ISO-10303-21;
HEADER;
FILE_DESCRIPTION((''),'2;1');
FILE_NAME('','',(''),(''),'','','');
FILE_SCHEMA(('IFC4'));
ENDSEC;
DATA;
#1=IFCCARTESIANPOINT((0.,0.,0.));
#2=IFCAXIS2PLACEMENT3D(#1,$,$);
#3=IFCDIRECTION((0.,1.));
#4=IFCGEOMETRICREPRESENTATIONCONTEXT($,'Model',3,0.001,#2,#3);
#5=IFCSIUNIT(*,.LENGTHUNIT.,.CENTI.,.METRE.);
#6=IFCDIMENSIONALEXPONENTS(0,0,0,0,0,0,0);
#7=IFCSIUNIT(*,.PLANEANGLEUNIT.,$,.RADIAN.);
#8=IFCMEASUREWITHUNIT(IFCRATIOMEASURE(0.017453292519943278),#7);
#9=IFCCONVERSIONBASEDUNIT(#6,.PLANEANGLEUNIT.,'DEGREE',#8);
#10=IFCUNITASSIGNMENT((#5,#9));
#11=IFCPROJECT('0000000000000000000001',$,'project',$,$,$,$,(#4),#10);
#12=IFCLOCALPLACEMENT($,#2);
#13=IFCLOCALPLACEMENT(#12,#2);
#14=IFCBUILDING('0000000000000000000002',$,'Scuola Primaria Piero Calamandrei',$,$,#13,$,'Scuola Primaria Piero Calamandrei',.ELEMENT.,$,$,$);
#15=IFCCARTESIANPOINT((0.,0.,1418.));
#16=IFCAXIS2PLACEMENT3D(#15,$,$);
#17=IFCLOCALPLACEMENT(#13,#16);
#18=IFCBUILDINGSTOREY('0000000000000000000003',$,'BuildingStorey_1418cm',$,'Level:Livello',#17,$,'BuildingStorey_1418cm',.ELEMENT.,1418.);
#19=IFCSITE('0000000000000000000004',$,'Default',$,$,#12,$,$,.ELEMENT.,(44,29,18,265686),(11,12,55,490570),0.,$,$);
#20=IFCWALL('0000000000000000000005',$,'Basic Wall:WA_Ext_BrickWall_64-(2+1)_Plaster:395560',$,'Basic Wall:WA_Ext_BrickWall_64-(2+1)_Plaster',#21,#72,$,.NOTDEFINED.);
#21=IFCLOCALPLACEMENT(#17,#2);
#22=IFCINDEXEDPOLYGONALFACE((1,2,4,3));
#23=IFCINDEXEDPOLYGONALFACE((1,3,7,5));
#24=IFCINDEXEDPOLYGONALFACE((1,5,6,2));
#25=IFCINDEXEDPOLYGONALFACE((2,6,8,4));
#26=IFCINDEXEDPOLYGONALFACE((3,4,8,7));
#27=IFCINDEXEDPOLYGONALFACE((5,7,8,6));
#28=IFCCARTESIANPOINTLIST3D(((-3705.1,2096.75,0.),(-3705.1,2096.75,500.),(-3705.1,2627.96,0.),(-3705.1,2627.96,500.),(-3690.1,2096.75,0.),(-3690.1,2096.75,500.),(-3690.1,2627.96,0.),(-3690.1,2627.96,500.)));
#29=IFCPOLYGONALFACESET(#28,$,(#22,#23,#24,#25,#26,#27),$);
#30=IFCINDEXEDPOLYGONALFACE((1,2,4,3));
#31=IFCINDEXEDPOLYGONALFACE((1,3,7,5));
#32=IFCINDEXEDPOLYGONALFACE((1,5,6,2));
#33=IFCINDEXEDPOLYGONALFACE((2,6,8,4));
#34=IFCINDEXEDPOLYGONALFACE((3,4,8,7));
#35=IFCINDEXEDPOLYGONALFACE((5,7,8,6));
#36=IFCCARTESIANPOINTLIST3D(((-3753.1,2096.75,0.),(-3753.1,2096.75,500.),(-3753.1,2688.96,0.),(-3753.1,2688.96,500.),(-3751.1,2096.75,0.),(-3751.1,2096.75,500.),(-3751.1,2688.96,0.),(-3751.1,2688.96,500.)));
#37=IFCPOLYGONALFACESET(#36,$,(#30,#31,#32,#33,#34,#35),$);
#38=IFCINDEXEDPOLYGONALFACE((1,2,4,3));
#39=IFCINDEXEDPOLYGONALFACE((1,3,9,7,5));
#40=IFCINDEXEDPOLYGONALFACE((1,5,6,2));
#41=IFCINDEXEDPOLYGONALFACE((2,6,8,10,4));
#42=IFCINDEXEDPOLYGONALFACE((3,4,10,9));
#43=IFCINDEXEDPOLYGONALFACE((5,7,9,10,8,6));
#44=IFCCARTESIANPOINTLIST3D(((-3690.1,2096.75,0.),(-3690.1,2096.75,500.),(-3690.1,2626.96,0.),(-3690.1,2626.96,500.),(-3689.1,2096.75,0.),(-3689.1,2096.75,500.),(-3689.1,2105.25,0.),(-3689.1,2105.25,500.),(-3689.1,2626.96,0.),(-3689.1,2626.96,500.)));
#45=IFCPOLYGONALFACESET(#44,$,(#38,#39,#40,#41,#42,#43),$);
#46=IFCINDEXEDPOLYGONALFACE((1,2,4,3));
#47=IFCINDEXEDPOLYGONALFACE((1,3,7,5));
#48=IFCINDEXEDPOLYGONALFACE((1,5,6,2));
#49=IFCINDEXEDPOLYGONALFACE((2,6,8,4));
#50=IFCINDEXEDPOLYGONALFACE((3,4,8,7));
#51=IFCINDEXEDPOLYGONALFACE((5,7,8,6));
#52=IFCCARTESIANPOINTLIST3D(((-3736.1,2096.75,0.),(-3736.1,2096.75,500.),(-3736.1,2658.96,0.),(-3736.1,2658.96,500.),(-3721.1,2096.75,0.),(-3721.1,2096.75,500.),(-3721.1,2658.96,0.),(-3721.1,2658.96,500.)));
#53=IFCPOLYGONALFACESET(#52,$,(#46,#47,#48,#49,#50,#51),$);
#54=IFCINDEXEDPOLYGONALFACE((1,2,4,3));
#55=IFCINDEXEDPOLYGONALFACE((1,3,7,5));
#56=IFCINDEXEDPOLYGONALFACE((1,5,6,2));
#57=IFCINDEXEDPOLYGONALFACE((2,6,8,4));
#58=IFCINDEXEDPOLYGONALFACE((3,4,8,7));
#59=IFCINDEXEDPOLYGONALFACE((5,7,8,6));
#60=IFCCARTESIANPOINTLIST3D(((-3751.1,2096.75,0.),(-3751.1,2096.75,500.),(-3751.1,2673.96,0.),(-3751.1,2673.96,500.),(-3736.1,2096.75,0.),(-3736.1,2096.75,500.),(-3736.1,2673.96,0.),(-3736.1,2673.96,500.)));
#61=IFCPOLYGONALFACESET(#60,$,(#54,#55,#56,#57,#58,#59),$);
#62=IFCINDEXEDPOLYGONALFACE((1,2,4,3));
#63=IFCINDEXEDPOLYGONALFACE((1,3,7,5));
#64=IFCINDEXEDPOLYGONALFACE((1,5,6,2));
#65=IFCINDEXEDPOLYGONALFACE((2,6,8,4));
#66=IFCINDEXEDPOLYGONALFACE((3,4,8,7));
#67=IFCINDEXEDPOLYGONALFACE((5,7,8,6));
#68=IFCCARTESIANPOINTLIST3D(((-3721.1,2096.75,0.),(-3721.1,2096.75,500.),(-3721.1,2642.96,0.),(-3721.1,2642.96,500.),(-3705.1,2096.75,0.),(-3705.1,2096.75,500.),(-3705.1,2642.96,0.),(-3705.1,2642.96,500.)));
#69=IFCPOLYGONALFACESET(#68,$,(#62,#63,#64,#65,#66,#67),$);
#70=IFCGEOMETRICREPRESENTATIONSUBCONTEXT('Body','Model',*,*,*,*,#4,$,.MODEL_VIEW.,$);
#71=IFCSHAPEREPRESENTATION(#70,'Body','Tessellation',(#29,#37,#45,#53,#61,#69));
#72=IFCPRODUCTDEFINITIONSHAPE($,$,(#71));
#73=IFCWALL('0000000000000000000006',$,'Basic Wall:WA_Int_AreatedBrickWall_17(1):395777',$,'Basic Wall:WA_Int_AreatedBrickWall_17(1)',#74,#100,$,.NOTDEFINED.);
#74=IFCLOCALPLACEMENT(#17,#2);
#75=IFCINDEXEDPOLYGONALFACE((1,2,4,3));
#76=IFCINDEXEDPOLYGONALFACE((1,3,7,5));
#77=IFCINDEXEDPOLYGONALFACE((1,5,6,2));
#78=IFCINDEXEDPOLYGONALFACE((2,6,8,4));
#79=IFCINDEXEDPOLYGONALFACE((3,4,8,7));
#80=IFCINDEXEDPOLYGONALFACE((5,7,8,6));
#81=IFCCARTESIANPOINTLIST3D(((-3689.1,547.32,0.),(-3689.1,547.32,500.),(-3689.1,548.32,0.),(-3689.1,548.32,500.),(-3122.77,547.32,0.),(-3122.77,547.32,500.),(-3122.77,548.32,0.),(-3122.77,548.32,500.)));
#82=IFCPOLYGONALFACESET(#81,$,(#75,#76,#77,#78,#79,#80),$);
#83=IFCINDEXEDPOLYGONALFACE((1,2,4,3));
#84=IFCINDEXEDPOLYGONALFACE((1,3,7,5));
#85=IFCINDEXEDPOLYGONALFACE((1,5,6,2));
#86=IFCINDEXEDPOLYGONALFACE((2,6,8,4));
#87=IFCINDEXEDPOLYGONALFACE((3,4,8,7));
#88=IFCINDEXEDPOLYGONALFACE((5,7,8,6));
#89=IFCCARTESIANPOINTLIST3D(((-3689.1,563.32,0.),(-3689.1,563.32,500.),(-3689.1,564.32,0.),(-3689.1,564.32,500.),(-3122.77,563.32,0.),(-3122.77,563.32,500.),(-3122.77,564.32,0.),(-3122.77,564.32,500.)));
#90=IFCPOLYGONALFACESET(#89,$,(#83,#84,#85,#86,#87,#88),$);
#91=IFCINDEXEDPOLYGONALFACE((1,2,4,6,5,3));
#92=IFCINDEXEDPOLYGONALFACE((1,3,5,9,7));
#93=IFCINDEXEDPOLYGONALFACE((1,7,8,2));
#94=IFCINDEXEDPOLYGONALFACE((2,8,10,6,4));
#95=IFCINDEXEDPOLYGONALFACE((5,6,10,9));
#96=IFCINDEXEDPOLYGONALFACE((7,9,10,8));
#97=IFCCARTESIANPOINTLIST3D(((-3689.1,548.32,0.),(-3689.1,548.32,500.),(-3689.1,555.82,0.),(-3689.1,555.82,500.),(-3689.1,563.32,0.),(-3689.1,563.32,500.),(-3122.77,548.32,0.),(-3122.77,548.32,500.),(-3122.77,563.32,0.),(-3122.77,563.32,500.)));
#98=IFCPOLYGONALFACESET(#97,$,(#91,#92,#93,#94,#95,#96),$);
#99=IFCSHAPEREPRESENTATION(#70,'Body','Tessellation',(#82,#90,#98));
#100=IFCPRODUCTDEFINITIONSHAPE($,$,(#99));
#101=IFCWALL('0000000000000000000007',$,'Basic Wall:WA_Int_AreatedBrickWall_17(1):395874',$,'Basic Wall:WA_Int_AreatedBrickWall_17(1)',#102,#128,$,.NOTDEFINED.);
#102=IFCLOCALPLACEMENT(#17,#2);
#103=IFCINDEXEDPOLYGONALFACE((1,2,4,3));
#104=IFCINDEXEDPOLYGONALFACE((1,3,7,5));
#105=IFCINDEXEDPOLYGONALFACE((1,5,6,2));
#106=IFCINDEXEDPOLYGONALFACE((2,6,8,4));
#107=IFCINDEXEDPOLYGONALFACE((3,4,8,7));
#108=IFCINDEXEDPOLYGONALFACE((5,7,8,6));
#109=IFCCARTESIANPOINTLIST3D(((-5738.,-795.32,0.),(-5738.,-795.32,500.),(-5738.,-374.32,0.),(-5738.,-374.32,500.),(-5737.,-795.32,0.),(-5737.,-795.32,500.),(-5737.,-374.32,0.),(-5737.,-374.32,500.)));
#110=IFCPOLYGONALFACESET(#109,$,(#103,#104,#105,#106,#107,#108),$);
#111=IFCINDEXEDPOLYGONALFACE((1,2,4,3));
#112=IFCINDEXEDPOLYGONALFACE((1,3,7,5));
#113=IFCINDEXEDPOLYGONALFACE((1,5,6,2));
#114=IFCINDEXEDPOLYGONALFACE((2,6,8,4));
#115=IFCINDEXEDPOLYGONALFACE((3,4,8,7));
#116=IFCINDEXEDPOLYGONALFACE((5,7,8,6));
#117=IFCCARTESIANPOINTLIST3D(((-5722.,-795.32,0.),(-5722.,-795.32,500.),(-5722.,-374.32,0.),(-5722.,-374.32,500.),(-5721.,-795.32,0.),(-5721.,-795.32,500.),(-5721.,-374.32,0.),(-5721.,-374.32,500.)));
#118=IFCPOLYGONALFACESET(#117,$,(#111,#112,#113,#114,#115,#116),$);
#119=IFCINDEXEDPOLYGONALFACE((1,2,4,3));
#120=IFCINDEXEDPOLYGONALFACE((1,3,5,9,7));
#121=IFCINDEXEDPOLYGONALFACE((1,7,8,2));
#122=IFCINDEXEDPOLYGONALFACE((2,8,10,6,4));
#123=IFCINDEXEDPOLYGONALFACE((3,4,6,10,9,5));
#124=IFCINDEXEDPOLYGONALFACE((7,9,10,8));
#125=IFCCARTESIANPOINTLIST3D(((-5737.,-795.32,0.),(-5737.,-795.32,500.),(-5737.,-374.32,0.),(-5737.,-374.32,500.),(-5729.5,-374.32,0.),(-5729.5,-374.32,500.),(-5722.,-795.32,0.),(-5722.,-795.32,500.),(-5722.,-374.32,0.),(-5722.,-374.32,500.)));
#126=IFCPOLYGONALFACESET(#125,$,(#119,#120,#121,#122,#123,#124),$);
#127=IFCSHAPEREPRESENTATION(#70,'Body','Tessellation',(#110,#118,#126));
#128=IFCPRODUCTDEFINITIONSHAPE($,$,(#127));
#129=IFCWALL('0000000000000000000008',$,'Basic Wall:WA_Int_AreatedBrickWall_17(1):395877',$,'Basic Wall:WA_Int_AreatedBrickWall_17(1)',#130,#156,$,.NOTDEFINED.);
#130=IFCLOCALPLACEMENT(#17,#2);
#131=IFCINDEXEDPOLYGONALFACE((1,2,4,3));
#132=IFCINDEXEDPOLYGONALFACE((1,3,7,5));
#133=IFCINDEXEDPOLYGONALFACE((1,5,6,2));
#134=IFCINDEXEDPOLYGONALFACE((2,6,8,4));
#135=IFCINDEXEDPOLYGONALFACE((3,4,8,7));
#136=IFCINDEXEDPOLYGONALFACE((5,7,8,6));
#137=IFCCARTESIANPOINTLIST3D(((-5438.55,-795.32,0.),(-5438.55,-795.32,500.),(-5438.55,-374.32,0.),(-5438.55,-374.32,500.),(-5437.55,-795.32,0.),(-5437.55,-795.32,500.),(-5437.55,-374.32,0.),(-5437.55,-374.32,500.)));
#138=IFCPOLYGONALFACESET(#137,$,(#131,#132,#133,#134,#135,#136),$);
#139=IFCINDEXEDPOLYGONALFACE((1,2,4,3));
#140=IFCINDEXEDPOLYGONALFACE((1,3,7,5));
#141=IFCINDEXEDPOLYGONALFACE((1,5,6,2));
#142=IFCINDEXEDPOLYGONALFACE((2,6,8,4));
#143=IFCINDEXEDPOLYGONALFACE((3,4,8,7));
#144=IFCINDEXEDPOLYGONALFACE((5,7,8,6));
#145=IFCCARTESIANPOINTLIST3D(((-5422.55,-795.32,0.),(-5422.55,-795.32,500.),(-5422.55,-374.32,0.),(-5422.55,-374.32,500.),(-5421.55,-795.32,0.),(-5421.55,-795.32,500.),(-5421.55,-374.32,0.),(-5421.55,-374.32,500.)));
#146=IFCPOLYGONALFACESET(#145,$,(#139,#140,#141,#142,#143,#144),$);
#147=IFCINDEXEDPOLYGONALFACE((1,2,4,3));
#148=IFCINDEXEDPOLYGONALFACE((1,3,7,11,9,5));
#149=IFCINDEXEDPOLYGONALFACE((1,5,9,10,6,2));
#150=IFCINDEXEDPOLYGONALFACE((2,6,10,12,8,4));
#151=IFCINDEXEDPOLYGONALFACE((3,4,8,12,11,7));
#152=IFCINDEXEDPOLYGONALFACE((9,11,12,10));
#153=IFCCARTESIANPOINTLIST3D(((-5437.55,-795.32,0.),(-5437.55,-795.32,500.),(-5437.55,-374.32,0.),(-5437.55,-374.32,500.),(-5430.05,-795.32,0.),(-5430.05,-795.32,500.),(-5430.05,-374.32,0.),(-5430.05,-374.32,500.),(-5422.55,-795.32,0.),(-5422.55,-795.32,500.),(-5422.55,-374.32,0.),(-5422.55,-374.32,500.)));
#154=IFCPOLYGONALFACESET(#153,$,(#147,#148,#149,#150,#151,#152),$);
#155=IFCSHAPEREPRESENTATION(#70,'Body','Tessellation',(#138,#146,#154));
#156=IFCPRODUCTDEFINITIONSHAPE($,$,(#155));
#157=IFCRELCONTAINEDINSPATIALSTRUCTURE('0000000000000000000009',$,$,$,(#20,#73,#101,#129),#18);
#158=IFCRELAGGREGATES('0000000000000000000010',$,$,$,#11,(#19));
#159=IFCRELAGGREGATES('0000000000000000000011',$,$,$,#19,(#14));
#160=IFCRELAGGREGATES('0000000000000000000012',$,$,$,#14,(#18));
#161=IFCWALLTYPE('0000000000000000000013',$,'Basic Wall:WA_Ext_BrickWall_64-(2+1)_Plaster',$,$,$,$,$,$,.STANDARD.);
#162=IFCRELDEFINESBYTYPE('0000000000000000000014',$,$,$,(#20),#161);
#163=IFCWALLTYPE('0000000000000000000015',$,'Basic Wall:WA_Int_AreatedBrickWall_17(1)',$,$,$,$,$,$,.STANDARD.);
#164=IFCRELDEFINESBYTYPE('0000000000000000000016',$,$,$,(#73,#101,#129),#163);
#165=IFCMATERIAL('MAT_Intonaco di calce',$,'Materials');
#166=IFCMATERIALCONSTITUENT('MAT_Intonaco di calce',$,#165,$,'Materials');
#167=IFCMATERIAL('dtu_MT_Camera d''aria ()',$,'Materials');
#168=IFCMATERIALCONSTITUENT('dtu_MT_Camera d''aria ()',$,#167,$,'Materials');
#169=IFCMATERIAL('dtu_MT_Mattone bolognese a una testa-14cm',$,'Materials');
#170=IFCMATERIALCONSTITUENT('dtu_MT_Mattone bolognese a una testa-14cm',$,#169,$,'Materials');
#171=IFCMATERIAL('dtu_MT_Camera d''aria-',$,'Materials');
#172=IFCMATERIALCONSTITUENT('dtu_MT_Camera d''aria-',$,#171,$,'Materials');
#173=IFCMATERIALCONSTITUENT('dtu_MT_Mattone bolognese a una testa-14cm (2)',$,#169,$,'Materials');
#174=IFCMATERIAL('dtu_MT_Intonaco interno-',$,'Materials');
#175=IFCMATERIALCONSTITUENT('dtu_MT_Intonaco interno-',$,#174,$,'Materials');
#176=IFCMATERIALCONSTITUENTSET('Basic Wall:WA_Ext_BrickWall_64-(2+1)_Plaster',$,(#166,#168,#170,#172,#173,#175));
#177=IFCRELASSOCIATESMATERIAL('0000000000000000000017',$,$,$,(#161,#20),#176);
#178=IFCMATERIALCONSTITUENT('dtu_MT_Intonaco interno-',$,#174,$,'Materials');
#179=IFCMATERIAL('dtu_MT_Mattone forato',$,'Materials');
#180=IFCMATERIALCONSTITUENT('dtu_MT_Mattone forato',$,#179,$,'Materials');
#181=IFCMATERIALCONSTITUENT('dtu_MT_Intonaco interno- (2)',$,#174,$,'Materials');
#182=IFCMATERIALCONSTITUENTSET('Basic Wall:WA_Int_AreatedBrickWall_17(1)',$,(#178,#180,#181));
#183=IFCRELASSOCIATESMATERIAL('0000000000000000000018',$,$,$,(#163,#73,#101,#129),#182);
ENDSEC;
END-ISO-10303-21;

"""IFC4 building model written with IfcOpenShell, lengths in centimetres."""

from ifc_helpers import new_model, entity, si_unit, converted_unit, direction, frame, origin, place, context, subcontext, project, spatial, indexed_curve, outline, extrude, material, constituent, constituent_set, type_object, element, save


model = new_model("IFC4")

# Units and contexts
model_context = context("Model", 3, precision=0.001, world=origin(), true_north=direction((0.0, 1.0)))
body_context = subcontext(model_context, "Body", "Model", "MODEL_VIEW")
ifc_project = project(units=[si_unit("LENGTHUNIT", "METRE", prefix="CENTI"), converted_unit("PLANEANGLEUNIT", "DEGREE", entity("IfcRatioMeasure", 0.017453292519943278), si_unit("PLANEANGLEUNIT", "RADIAN"), dimensions=[0, 0, 0, 0, 0, 0, 0])], contexts=[model_context])

# Site, building, storey
site_placement = place(None, origin())
site = spatial("IfcSite", under=ifc_project, at=site_placement, Name="Default", CompositionType="ELEMENT", RefLatitude=(44, 29, 18, 265686), RefLongitude=(11, 12, 55, 490570), RefElevation=0.0)
building_placement = place(site_placement, origin())
building = spatial("IfcBuilding", under=site, at=building_placement, Name="Scuola Primaria Piero Calamandrei", LongName="Scuola Primaria Piero Calamandrei", CompositionType="ELEMENT")
storey_placement = place(building_placement, frame((0.0, 0.0, 1418.0)))
storey = spatial("IfcBuildingStorey", under=building, at=storey_placement, Name="BuildingStorey_1418cm", ObjectType="Level:Livello", LongName="BuildingStorey_1418cm", CompositionType="ELEMENT", Elevation=1418.0)

# Shared definitions
ifc_material_1 = material(Name="MAT_Intonaco di calce", Category="Materials")
ifc_constituent_1 = constituent(ifc_material_1, Name="MAT_Intonaco di calce", Category="Materials")
ifc_material_2 = material(Name="dtu_MT_Camera d'aria ()", Category="Materials")
ifc_constituent_2 = constituent(ifc_material_2, Name="dtu_MT_Camera d'aria ()", Category="Materials")
ifc_material_3 = material(Name="dtu_MT_Mattone bolognese a una testa-14cm", Category="Materials")
ifc_constituent_3 = constituent(ifc_material_3, Name="dtu_MT_Mattone bolognese a una testa-14cm", Category="Materials")
ifc_material_4 = material(Name="dtu_MT_Camera d'aria-", Category="Materials")
ifc_constituent_4 = constituent(ifc_material_4, Name="dtu_MT_Camera d'aria-", Category="Materials")
ifc_constituent_5 = constituent(ifc_material_3, Name="dtu_MT_Mattone bolognese a una testa-14cm (2)", Category="Materials")
ifc_material_5 = material(Name="dtu_MT_Intonaco interno-", Category="Materials")
ifc_constituent_6 = constituent(ifc_material_5, Name="dtu_MT_Intonaco interno-", Category="Materials")
ifc_constituent_set_1 = constituent_set(constituents=[ifc_constituent_1, ifc_constituent_2, ifc_constituent_3, ifc_constituent_4, ifc_constituent_5, ifc_constituent_6], Name="Basic Wall:WA_Ext_BrickWall_64-(2+1)_Plaster")
wall_type_1 = type_object("IfcWallType", Name="Basic Wall:WA_Ext_BrickWall_64-(2+1)_Plaster", PredefinedType="STANDARD", material=ifc_constituent_set_1)

# Wall
wall_1_placement = place(storey_placement, frame((-3721.1, 2096.75, 0.0), z_axis=(0.0, 0.0, 1.0), x_axis=(0.0, 1.0, 0.0)))
element("IfcWall", 1, at=wall_1_placement, inside=storey, type_object=wall_type_1, material=ifc_constituent_set_1, Name="Basic Wall:WA_Ext_BrickWall_64-(2+1)_Plaster:395560", ObjectType="Basic Wall:WA_Ext_BrickWall_64-(2+1)_Plaster", PredefinedType="NOTDEFINED", context=body_context, shape_type="SweptSolid", body=[
    extrude(outline(indexed_curve([(-265.61, -7.5), (265.61, -7.5), (265.61, 7.5), (-265.61, 7.5), (-265.61, -7.5)], self_intersect=False)), frame((265.61, -23.5, 0.0)), (0.0, 0.0, 1.0), 500.0),
    extrude(outline(indexed_curve([(-1.0, -296.11), (1.0, -296.11), (1.0, 296.11), (-1.0, 296.11), (-1.0, -296.11)], self_intersect=False)), frame((296.11, 31.0, 0.0), z_axis=(0.0, 0.0, 1.0), x_axis=(0.0, -1.0, 0.0)), (0.0, 0.0, 1.0), 500.0),
    extrude(outline(indexed_curve([(-205.29, -0.4), (316.43, -0.4), (316.43, 0.6), (-213.79, 0.6), (-213.79, -0.4), (-205.29, -0.4)], self_intersect=False)), frame((213.79, -31.6, 0.0)), (0.0, 0.0, 1.0), 500.0),
    extrude(outline(indexed_curve([(-281.11, -7.5), (281.11, -7.5), (281.11, 7.5), (-281.11, 7.5), (-281.11, -7.5)], self_intersect=False)), frame((281.11, 7.5, 0.0)), (0.0, 0.0, 1.0), 500.0),
    extrude(outline(indexed_curve([(-288.61, -7.5), (288.61, -7.5), (288.61, 7.5), (-288.61, 7.5), (-288.61, -7.5)], self_intersect=False)), frame((288.61, 22.5, 0.0)), (0.0, 0.0, 1.0), 500.0),
    extrude(outline(indexed_curve([(-273.11, -8.0), (273.11, -8.0), (273.11, 8.0), (-273.11, 8.0), (-273.11, -8.0)], self_intersect=False)), frame((273.11, -8.0, 0.0)), (0.0, 0.0, 1.0), 500.0),
])

# Walls
ifc_constituent_7 = constituent(ifc_material_5, Name="dtu_MT_Intonaco interno-", Category="Materials")
ifc_material_6 = material(Name="dtu_MT_Mattone forato", Category="Materials")
ifc_constituent_8 = constituent(ifc_material_6, Name="dtu_MT_Mattone forato", Category="Materials")
ifc_constituent_9 = constituent(ifc_material_5, Name="dtu_MT_Intonaco interno- (2)", Category="Materials")
ifc_constituent_set_2 = constituent_set(constituents=[ifc_constituent_7, ifc_constituent_8, ifc_constituent_9], Name="Basic Wall:WA_Int_AreatedBrickWall_17(1)")
wall_type_2 = type_object("IfcWallType", Name="Basic Wall:WA_Int_AreatedBrickWall_17(1)", PredefinedType="STANDARD", material=ifc_constituent_set_2)
wall_2_placement = place(storey_placement, frame((-3689.1, 555.82, 0.0)))
element("IfcWall", 2, at=wall_2_placement, inside=storey, type_object=wall_type_2, material=ifc_constituent_set_2, Name="Basic Wall:WA_Int_AreatedBrickWall_17(1):395777", ObjectType="Basic Wall:WA_Int_AreatedBrickWall_17(1)", PredefinedType="NOTDEFINED", context=body_context, shape_type="SweptSolid", body=[
    extrude(outline(indexed_curve([(-0.5, -283.17), (0.5, -283.17), (0.5, 283.17), (-0.5, 283.17), (-0.5, -283.17)], self_intersect=False)), frame((283.17, -8.0, 0.0), z_axis=(0.0, 0.0, 1.0), x_axis=(0.0, 1.0, 0.0)), (0.0, 0.0, 1.0), 500.0),
    extrude(outline(indexed_curve([(-0.5, -283.17), (0.5, -283.17), (0.5, 283.17), (-0.5, 283.17), (-0.5, -283.17)], self_intersect=False)), frame((283.17, 8.0, 0.0), z_axis=(0.0, 0.0, 1.0), x_axis=(0.0, -1.0, 0.0)), (0.0, 0.0, 1.0), 500.0),
    extrude(outline(indexed_curve([(-226.53, -7.5), (339.8, -7.5), (339.8, 7.5), (-226.53, 7.5), (-226.53, 0.0), (-226.53, -7.5)], self_intersect=False)), frame((226.53, 0.0, 0.0)), (0.0, 0.0, 1.0), 500.0),
])
wall_3_placement = place(storey_placement, frame((-5729.5, -374.32, 0.0), z_axis=(0.0, 0.0, 1.0), x_axis=(0.0, -1.0, 0.0)))
element("IfcWall", 3, at=wall_3_placement, inside=storey, type_object=wall_type_2, material=ifc_constituent_set_2, Name="Basic Wall:WA_Int_AreatedBrickWall_17(1):395874", ObjectType="Basic Wall:WA_Int_AreatedBrickWall_17(1)", PredefinedType="NOTDEFINED", context=body_context, shape_type="SweptSolid", body=[
    extrude(outline(indexed_curve([(-0.5, -210.5), (0.5, -210.5), (0.5, 210.5), (-0.5, 210.5), (-0.5, -210.5)], self_intersect=False)), frame((210.5, -8.0, 0.0), z_axis=(0.0, 0.0, 1.0), x_axis=(0.0, 1.0, 0.0)), (0.0, 0.0, 1.0), 500.0),
    extrude(outline(indexed_curve([(-0.5, -210.5), (0.5, -210.5), (0.5, 210.5), (-0.5, 210.5), (-0.5, -210.5)], self_intersect=False)), frame((210.5, 8.0, 0.0), z_axis=(0.0, 0.0, 1.0), x_axis=(0.0, -1.0, 0.0)), (0.0, 0.0, 1.0), 500.0),
    extrude(outline(indexed_curve([(-168.4, -7.5), (252.6, -7.5), (252.6, 7.5), (-168.4, 7.5), (-168.4, 0.0), (-168.4, -7.5)], self_intersect=False)), frame((168.4, 0.0, 0.0)), (0.0, 0.0, 1.0), 500.0),
])
wall_4_placement = place(storey_placement, frame((-5430.05, -374.32, 0.0), z_axis=(0.0, 0.0, 1.0), x_axis=(0.0, -1.0, 0.0)))
element("IfcWall", 4, at=wall_4_placement, inside=storey, type_object=wall_type_2, material=ifc_constituent_set_2, Name="Basic Wall:WA_Int_AreatedBrickWall_17(1):395877", ObjectType="Basic Wall:WA_Int_AreatedBrickWall_17(1)", PredefinedType="NOTDEFINED", context=body_context, shape_type="SweptSolid", body=[
    extrude(outline(indexed_curve([(-0.5, -210.5), (0.5, -210.5), (0.5, 210.5), (-0.5, 210.5), (-0.5, -210.5)], self_intersect=False)), frame((210.5, -8.0, 0.0), z_axis=(0.0, 0.0, 1.0), x_axis=(0.0, 1.0, 0.0)), (0.0, 0.0, 1.0), 500.0),
    extrude(outline(indexed_curve([(-0.5, -210.5), (0.5, -210.5), (0.5, 210.5), (-0.5, 210.5), (-0.5, -210.5)], self_intersect=False)), frame((210.5, 8.0, 0.0), z_axis=(0.0, 0.0, 1.0), x_axis=(0.0, -1.0, 0.0)), (0.0, 0.0, 1.0), 500.0),
    extrude(outline(indexed_curve([(-210.5, -7.5), (210.5, -7.5), (210.5, 0.0), (210.5, 7.5), (-210.5, 7.5), (-210.5, 0.0), (-210.5, -7.5)], self_intersect=False)), frame((210.5, 0.0, 0.0)), (0.0, 0.0, 1.0), 500.0),
])

save(model, "model.ifc")
